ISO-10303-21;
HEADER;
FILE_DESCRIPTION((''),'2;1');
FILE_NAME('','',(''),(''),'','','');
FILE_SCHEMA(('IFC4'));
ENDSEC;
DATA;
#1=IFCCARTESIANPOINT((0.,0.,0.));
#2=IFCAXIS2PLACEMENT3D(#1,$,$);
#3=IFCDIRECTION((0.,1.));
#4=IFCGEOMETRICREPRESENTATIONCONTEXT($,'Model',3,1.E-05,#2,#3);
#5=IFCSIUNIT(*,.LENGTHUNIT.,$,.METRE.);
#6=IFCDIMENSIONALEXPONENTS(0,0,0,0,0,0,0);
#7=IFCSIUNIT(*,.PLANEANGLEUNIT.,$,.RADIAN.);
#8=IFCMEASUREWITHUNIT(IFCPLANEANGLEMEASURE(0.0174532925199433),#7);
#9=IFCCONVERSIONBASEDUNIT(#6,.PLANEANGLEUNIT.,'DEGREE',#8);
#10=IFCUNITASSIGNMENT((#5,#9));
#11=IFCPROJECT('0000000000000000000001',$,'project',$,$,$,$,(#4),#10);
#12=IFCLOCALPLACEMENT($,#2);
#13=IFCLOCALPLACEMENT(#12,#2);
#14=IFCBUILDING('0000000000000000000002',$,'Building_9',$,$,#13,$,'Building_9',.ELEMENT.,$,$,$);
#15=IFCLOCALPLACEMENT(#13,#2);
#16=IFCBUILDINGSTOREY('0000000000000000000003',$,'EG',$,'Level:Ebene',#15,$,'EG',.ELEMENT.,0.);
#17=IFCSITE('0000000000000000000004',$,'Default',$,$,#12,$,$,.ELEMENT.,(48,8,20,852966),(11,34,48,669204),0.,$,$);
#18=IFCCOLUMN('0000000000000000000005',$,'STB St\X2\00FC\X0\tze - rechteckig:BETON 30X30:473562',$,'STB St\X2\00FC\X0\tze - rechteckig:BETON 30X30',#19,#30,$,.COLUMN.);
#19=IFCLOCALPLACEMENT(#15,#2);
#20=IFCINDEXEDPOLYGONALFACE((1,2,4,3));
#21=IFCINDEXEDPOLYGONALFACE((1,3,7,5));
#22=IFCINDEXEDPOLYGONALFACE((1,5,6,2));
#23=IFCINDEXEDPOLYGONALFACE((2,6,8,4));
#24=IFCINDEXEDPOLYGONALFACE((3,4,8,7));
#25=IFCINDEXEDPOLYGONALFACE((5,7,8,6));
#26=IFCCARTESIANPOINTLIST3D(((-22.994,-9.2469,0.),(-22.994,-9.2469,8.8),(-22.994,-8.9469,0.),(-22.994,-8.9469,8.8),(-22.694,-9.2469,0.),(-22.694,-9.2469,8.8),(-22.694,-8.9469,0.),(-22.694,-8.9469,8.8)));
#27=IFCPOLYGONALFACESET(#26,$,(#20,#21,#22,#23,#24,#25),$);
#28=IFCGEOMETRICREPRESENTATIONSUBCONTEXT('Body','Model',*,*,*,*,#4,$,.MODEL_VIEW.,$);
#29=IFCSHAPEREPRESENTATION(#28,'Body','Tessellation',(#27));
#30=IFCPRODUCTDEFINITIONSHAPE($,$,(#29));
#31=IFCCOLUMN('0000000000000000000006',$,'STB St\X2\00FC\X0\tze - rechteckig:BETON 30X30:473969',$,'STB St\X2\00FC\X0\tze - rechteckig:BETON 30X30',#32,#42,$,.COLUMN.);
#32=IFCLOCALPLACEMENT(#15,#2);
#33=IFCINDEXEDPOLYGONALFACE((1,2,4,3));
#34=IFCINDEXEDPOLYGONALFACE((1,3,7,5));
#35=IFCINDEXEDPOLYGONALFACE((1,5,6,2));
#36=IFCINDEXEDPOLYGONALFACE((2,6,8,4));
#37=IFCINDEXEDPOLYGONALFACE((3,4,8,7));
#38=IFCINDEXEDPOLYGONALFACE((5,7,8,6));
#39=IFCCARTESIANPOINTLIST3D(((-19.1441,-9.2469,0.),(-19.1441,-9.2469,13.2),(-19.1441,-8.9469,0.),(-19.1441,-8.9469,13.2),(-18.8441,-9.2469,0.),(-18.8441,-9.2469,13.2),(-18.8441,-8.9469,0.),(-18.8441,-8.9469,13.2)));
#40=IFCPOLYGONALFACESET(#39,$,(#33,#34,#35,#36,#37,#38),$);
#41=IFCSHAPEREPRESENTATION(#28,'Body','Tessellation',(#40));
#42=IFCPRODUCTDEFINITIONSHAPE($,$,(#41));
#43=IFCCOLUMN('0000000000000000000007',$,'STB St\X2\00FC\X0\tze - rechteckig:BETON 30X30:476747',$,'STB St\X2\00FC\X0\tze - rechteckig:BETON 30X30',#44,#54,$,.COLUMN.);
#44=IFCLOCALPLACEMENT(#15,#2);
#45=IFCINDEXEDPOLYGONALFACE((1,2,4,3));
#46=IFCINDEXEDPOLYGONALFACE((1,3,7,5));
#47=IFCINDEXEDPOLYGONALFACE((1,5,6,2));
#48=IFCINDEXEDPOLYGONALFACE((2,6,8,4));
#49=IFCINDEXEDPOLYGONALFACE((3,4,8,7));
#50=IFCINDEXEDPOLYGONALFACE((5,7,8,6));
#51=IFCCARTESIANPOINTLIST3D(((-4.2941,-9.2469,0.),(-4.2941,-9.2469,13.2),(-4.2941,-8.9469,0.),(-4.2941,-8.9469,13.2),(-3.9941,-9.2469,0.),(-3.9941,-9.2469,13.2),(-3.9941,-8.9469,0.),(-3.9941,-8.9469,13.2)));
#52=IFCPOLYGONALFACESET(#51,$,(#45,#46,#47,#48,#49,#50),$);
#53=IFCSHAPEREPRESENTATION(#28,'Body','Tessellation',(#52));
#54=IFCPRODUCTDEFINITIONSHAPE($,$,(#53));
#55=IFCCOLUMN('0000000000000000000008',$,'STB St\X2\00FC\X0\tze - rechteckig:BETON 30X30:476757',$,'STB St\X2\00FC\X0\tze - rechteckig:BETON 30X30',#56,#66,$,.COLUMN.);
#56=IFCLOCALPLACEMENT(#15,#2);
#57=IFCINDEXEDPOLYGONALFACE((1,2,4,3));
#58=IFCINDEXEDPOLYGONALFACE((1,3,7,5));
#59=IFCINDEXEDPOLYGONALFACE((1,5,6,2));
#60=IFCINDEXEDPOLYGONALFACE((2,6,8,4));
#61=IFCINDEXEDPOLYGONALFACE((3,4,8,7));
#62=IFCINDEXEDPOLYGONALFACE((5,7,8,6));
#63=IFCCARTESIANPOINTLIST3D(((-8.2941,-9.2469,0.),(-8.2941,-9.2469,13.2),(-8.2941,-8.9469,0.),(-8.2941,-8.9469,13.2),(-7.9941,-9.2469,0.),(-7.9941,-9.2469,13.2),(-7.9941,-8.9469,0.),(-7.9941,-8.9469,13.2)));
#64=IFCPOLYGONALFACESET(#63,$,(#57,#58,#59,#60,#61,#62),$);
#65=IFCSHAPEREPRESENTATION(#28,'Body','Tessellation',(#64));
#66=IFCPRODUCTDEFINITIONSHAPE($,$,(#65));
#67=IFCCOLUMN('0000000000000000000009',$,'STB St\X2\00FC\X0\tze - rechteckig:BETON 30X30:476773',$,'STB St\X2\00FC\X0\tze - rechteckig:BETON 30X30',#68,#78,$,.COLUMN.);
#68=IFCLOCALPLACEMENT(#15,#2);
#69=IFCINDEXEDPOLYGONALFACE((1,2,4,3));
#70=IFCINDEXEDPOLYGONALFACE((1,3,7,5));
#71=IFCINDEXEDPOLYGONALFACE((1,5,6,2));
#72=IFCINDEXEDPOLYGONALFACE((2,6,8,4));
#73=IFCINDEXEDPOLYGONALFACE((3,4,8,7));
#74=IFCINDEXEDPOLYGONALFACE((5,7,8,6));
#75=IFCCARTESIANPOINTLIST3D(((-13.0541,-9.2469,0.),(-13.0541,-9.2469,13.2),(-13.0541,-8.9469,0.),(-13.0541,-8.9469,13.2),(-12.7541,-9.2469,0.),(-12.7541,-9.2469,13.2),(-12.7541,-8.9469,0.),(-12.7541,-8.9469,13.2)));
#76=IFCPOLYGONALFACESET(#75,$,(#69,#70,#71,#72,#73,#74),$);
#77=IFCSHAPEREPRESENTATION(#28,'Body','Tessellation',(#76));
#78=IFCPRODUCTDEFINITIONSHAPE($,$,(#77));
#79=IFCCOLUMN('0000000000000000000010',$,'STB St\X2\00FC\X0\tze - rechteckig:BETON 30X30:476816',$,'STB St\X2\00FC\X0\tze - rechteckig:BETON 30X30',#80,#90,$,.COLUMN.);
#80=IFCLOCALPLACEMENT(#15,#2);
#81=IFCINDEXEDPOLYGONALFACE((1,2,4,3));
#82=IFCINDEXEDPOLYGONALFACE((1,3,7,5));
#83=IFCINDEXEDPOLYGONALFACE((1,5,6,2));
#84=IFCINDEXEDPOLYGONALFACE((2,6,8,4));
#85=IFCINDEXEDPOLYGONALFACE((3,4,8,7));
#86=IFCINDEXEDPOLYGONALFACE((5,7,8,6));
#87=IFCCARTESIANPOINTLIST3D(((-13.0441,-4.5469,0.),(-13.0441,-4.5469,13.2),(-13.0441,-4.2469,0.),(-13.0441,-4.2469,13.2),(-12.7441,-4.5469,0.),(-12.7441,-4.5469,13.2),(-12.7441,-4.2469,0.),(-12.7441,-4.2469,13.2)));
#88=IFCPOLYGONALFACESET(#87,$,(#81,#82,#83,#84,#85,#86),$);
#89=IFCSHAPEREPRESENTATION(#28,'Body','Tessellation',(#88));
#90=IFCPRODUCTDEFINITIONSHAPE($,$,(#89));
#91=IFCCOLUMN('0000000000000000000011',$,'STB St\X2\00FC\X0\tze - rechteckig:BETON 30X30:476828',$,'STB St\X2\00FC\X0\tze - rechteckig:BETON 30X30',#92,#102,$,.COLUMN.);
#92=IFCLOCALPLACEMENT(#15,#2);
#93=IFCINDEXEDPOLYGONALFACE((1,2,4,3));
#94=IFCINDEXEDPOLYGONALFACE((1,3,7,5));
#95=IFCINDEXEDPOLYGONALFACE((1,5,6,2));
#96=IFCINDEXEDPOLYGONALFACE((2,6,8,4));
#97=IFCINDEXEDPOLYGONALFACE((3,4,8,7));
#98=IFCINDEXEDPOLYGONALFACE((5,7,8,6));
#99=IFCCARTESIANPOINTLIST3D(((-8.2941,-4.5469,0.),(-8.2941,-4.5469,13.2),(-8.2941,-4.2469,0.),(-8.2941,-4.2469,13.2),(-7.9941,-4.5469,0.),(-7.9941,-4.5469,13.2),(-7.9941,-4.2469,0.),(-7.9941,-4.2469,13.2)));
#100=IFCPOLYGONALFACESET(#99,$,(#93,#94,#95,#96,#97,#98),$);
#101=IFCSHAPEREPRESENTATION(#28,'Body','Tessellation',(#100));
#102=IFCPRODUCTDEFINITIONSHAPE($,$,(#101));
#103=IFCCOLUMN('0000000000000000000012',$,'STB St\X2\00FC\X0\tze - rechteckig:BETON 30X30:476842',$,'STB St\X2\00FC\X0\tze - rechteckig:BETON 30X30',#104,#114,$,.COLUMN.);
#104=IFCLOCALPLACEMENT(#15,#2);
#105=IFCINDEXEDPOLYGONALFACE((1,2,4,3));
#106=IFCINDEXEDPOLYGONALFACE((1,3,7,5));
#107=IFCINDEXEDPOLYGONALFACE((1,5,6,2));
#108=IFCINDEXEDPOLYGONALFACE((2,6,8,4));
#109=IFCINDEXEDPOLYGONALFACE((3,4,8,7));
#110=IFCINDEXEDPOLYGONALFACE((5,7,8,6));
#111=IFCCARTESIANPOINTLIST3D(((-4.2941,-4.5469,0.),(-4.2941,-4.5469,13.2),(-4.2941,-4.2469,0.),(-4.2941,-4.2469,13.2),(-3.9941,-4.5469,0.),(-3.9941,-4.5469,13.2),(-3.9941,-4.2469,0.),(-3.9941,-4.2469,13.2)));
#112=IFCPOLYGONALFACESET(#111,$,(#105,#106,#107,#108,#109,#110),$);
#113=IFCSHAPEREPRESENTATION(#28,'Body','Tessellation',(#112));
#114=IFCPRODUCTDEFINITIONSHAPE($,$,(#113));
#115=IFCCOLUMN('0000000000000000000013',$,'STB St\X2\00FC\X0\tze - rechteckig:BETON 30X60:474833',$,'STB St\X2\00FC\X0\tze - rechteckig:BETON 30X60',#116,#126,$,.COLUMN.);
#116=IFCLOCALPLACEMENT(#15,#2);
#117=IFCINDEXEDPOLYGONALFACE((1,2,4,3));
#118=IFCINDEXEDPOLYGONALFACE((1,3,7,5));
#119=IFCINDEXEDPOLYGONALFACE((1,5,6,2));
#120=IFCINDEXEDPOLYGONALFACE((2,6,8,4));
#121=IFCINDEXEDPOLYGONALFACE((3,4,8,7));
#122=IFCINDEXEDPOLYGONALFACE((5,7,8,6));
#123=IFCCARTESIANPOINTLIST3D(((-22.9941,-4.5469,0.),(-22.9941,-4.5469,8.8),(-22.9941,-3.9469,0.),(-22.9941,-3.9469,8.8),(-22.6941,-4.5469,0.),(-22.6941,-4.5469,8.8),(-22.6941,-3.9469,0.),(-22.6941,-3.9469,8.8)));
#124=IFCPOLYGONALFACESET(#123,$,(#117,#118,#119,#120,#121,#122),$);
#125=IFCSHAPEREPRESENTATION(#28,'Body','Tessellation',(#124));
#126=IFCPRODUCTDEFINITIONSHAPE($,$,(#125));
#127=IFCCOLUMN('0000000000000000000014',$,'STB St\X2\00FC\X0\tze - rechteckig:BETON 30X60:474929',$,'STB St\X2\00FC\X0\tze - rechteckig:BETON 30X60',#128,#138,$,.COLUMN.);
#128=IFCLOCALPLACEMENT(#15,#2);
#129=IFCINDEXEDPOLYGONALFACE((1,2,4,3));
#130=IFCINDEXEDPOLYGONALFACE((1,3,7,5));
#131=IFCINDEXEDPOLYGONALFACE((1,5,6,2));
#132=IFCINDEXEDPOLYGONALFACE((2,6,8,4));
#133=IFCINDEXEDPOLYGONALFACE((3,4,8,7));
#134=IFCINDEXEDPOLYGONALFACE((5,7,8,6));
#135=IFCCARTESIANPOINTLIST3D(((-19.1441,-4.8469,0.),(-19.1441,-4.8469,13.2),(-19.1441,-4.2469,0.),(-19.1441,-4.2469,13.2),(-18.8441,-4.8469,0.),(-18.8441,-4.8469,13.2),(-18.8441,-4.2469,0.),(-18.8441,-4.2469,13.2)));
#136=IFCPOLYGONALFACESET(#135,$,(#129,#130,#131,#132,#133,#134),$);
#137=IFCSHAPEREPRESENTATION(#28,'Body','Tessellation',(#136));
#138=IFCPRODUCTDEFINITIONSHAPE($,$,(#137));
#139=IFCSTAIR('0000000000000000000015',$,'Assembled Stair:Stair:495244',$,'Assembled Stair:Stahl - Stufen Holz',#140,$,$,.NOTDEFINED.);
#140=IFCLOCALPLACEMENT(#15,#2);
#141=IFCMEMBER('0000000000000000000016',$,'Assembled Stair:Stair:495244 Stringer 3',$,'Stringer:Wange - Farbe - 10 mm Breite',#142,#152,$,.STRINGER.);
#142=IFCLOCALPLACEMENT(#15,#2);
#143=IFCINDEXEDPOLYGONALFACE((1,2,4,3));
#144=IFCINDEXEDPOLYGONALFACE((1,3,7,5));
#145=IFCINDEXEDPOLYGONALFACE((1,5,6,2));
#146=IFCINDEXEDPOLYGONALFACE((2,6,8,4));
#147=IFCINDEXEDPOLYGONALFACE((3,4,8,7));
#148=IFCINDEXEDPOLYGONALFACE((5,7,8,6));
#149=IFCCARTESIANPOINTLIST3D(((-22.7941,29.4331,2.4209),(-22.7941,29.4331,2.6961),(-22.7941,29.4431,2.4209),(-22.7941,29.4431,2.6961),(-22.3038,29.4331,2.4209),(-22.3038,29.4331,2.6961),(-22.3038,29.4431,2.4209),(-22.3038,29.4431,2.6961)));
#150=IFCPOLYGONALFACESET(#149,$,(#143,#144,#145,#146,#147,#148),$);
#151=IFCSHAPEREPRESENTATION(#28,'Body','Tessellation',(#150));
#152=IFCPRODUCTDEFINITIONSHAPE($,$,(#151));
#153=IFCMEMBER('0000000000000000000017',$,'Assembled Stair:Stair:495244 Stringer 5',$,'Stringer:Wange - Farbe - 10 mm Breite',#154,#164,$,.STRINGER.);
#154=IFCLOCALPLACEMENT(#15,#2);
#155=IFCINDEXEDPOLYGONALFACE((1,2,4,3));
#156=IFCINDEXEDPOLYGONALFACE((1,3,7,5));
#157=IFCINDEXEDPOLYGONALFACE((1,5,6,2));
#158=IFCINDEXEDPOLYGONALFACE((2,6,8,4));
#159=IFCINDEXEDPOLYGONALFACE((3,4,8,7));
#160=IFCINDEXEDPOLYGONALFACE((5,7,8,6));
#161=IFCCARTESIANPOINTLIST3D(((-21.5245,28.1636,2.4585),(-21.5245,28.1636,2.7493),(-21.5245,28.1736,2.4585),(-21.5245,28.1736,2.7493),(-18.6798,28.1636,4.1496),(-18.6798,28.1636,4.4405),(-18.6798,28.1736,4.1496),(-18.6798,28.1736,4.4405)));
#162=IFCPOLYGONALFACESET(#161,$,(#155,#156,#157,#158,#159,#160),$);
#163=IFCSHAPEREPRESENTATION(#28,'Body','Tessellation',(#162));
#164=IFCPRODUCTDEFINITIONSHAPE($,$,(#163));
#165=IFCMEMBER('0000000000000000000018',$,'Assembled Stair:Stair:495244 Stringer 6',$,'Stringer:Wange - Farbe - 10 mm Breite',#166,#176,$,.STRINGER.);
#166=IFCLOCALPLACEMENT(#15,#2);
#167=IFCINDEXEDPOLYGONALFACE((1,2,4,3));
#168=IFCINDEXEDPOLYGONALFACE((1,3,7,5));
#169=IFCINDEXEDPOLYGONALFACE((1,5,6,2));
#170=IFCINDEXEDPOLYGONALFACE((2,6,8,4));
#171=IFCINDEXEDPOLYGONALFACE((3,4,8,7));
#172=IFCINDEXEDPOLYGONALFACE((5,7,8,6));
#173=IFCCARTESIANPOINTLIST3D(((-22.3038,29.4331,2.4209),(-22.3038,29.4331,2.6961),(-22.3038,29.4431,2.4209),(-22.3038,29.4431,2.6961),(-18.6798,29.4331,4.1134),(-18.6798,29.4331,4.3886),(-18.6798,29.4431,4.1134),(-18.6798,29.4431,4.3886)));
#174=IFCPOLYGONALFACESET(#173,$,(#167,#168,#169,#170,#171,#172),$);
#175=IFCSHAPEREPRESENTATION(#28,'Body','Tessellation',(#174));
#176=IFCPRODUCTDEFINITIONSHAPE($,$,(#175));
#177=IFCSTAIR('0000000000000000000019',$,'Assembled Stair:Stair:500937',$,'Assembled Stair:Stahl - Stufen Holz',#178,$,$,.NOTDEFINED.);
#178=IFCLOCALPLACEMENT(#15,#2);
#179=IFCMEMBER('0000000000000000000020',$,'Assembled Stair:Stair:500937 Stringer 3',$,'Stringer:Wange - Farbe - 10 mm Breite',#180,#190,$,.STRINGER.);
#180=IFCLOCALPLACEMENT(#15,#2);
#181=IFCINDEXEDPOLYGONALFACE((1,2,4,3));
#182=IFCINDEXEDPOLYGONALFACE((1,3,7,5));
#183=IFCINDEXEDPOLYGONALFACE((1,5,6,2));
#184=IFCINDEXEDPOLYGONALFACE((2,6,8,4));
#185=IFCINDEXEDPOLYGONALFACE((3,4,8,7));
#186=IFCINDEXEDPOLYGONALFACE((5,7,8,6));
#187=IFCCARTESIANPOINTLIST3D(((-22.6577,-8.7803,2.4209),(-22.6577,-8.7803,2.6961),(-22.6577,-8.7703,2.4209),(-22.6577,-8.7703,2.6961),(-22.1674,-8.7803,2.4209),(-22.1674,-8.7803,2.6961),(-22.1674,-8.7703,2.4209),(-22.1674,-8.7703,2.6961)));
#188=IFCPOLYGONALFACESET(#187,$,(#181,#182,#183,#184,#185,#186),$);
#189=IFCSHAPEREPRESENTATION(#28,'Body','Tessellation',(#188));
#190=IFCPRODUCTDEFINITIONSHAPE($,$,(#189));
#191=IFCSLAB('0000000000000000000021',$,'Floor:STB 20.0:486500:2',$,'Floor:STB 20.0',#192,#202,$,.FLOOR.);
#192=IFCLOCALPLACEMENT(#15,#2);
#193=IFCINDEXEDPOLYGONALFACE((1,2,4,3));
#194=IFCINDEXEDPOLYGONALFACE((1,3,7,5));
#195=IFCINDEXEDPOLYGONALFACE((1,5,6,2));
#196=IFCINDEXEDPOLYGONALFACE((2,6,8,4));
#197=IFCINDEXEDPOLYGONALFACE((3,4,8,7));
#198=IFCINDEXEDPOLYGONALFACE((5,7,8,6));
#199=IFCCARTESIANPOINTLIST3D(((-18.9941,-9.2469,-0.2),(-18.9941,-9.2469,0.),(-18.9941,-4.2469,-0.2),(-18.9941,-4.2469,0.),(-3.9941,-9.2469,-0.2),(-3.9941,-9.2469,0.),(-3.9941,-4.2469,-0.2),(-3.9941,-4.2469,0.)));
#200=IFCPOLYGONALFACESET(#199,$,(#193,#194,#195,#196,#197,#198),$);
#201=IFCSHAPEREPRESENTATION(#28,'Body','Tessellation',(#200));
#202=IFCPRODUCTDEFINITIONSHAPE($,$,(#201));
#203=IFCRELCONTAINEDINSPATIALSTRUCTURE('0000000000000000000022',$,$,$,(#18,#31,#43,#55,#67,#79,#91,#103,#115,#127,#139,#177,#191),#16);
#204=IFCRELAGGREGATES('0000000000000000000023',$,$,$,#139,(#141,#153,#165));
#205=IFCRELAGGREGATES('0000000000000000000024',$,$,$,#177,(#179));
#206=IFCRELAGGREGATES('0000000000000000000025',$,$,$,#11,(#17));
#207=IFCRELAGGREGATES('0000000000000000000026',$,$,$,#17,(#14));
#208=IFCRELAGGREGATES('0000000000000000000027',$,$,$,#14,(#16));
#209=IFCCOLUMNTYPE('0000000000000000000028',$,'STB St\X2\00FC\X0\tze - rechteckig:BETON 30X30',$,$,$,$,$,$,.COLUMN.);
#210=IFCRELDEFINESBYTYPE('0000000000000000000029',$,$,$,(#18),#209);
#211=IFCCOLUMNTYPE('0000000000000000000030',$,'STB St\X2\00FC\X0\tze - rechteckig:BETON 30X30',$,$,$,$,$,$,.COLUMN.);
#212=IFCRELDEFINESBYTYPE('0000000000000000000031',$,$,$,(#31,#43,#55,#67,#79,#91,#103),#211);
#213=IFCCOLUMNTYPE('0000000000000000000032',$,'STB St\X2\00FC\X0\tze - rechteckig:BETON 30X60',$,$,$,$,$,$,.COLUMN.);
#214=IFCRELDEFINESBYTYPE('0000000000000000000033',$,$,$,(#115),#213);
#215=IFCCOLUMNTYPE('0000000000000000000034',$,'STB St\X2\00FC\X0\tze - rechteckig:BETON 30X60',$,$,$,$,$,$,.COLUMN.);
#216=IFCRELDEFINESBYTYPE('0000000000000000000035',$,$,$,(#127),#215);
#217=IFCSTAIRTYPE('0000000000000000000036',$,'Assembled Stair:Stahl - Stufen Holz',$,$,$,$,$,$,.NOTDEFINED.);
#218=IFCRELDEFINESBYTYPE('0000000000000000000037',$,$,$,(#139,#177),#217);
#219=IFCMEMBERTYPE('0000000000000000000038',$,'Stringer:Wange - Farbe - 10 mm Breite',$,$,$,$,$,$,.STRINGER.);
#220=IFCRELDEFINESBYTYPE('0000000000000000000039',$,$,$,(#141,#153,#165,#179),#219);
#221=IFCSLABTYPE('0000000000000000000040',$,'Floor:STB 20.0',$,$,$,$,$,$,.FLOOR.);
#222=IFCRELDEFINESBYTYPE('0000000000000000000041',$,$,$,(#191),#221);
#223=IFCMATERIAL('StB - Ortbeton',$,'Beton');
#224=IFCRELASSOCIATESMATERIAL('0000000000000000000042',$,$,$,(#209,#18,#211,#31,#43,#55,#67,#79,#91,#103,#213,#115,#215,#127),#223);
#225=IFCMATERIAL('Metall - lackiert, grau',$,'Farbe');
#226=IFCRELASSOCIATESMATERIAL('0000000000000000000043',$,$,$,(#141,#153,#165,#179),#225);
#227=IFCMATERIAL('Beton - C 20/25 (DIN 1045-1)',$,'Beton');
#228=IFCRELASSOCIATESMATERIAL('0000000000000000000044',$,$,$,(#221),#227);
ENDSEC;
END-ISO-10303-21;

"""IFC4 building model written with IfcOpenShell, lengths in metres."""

from ifc_helpers import new_model, entity, si_unit, converted_unit, direction, frame, frame_2d, origin, place, context, subcontext, project, spatial, indexed_curve, rectangle, outline, extrude, source, transform, mapped, material, type_object, type_shapes, element, aggregate, save


model = new_model("IFC4")

# Units and contexts
model_context = context("Model", 3, precision=1e-05, world=origin(), true_north=direction((0.0, 1.0)))
body_context = subcontext(model_context, "Body", "Model", "MODEL_VIEW")
ifc_project = project(units=[si_unit("LENGTHUNIT", "METRE"), converted_unit("PLANEANGLEUNIT", "DEGREE", entity("IfcPlaneAngleMeasure", 0.0174532925199433), si_unit("PLANEANGLEUNIT", "RADIAN"), dimensions=[0, 0, 0, 0, 0, 0, 0])], contexts=[model_context])

# Site, building, storey
site_placement = place(None, origin())
site = spatial("IfcSite", under=ifc_project, at=site_placement, Name="Default", CompositionType="ELEMENT", RefLatitude=(48, 8, 20, 852966), RefLongitude=(11, 34, 48, 669204), RefElevation=0.0)
building_placement = place(site_placement, origin())
building = spatial("IfcBuilding", under=site, at=building_placement, Name="Building_9", LongName="Building_9", CompositionType="ELEMENT")
storey_placement = place(building_placement, origin())
storey = spatial("IfcBuildingStorey", under=building, at=storey_placement, Name="EG", ObjectType="Level:Ebene", LongName="EG", CompositionType="ELEMENT", Elevation=0.0)

# Columns
ifc_material_1 = material(Name="StB - Ortbeton", Category="Beton")
column_type_1 = type_object("IfcColumnType", Name="STB Stütze - rechteckig:BETON 30X30", PredefinedType="COLUMN", material=ifc_material_1)
shared_shape_1 = source(origin(), body_context, "Body", "SweptSolid", [
    extrude(outline(indexed_curve([(-0.15, -0.15), (0.15, -0.15), (0.15, 0.15), (-0.15, 0.15), (-0.15, -0.15)], self_intersect=False)), frame((0.0, 0.0, 0.0), z_axis=(0.0, 0.0, 1.0), x_axis=(-1.0, 0.0, 0.0)), (0.0, 0.0, 1.0), 8.8),
])
type_shapes(column_type_1, [shared_shape_1])
column_1_placement = place(storey_placement, frame((-22.844, -9.0969, 0.0)))
element("IfcColumn", 1, at=column_1_placement, inside=storey, type_object=column_type_1, material=ifc_material_1, Name="STB Stütze - rechteckig:BETON 30X30:473562", ObjectType="STB Stütze - rechteckig:BETON 30X30", PredefinedType="COLUMN", context=body_context, shape_type="MappedRepresentation", body=[
    mapped(shared_shape_1, transform((0.0, 0.0, 0.0), scale=1.0)),
])
column_type_2 = type_object("IfcColumnType", Name="STB Stütze - rechteckig:BETON 30X30", PredefinedType="COLUMN", material=ifc_material_1)
shared_shape_2 = source(origin(), body_context, "Body", "SweptSolid", [
    extrude(outline(indexed_curve([(-0.15, -0.15), (0.15, -0.15), (0.15, 0.15), (-0.15, 0.15), (-0.15, -0.15)], self_intersect=False)), frame((0.0, 0.0, 0.0), z_axis=(0.0, 0.0, 1.0), x_axis=(-1.0, 0.0, 0.0)), (0.0, 0.0, 1.0), 13.2),
])
type_shapes(column_type_2, [shared_shape_2])
for number, where, name in (
    (2, (-18.9941, -9.0969, 0.0), "STB Stütze - rechteckig:BETON 30X30:473969"),
    (3, (-4.1441, -9.0969, 0.0), "STB Stütze - rechteckig:BETON 30X30:476747"),
    (4, (-8.1441, -9.0969, 0.0), "STB Stütze - rechteckig:BETON 30X30:476757"),
    (5, (-12.9041, -9.0969, 0.0), "STB Stütze - rechteckig:BETON 30X30:476773"),
    (6, (-12.8941, -4.3969, 0.0), "STB Stütze - rechteckig:BETON 30X30:476816"),
    (7, (-8.1441, -4.3969, 0.0), "STB Stütze - rechteckig:BETON 30X30:476828"),
    (8, (-4.1441, -4.3969, 0.0), "STB Stütze - rechteckig:BETON 30X30:476842"),
):
    element("IfcColumn", number, at=place(storey_placement, frame(where)), inside=storey, type_object=column_type_2, material=ifc_material_1, Name=name, ObjectType="STB Stütze - rechteckig:BETON 30X30", PredefinedType="COLUMN", context=body_context, shape_type="MappedRepresentation", body=[
        mapped(shared_shape_2, transform((0.0, 0.0, 0.0), scale=1.0)),
    ])
column_type_3 = type_object("IfcColumnType", Name="STB Stütze - rechteckig:BETON 30X60", PredefinedType="COLUMN", material=ifc_material_1)
shared_shape_3 = source(origin(), body_context, "Body", "SweptSolid", [
    extrude(outline(indexed_curve([(-0.15, -0.3), (0.15, -0.3), (0.15, 0.3), (-0.15, 0.3), (-0.15, -0.3)], self_intersect=False)), frame((0.0, 0.0, 0.0), z_axis=(0.0, 0.0, 1.0), x_axis=(-1.0, 0.0, 0.0)), (0.0, 0.0, 1.0), 8.8),
])
type_shapes(column_type_3, [shared_shape_3])
column_2_placement = place(storey_placement, frame((-22.8441, -4.2469, 0.0)))
element("IfcColumn", 9, at=column_2_placement, inside=storey, type_object=column_type_3, material=ifc_material_1, Name="STB Stütze - rechteckig:BETON 30X60:474833", ObjectType="STB Stütze - rechteckig:BETON 30X60", PredefinedType="COLUMN", context=body_context, shape_type="MappedRepresentation", body=[
    mapped(shared_shape_3, transform((0.0, 0.0, 0.0), scale=1.0)),
])
column_type_4 = type_object("IfcColumnType", Name="STB Stütze - rechteckig:BETON 30X60", PredefinedType="COLUMN", material=ifc_material_1)
shared_shape_4 = source(origin(), body_context, "Body", "SweptSolid", [
    extrude(outline(indexed_curve([(-0.15, -0.3), (0.15, -0.3), (0.15, 0.3), (-0.15, 0.3), (-0.15, -0.3)], self_intersect=False)), frame((0.0, 0.0, 0.0), z_axis=(0.0, 0.0, 1.0), x_axis=(-1.0, 0.0, 0.0)), (0.0, 0.0, 1.0), 13.2),
])
type_shapes(column_type_4, [shared_shape_4])
column_3_placement = place(storey_placement, frame((-18.9941, -4.5469, 0.0)))
element("IfcColumn", 10, at=column_3_placement, inside=storey, type_object=column_type_4, material=ifc_material_1, Name="STB Stütze - rechteckig:BETON 30X60:474929", ObjectType="STB Stütze - rechteckig:BETON 30X60", PredefinedType="COLUMN", context=body_context, shape_type="MappedRepresentation", body=[
    mapped(shared_shape_4, transform((0.0, 0.0, 0.0), scale=1.0)),
])

# Stairs, members
stair_type = type_object("IfcStairType", Name="Assembled Stair:Stahl - Stufen Holz", PredefinedType="NOTDEFINED")
stair_1_placement = place(storey_placement, origin())
stair_1 = element("IfcStair", 11, at=stair_1_placement, inside=storey, type_object=stair_type, Name="Assembled Stair:Stair:495244", ObjectType="Assembled Stair:Stahl - Stufen Holz", PredefinedType="NOTDEFINED")
ifc_material_2 = material(Name="Metall - lackiert, grau", Category="Farbe")
member_type = type_object("IfcMemberType", Name="Stringer:Wange - Farbe - 10 mm Breite", PredefinedType="STRINGER")
member_1_placement = place(stair_1_placement, origin())
member_1 = element("IfcMember", 12, at=member_1_placement, type_object=member_type, material=ifc_material_2, Name="Assembled Stair:Stair:495244 Stringer 3", ObjectType="Stringer:Wange - Farbe - 10 mm Breite", PredefinedType="STRINGER", context=body_context, shape_type="SweptSolid", body=[
    extrude(outline(indexed_curve([(-0.2451, -0.005), (0.2451, -0.005), (0.2451, 0.005), (-0.2451, 0.005), (-0.2451, -0.005)], self_intersect=False)), frame((-22.5489, 29.4381, 2.4209)), (0.0, 0.0, 1.0), 0.2752),
])
member_2_placement = place(stair_1_placement, origin())
member_2 = element("IfcMember", 13, at=member_2_placement, type_object=member_type, material=ifc_material_2, Name="Assembled Stair:Stair:495244 Stringer 5", ObjectType="Stringer:Wange - Farbe - 10 mm Breite", PredefinedType="STRINGER", context=body_context, shape_type="SweptSolid", body=[
    extrude(outline(indexed_curve([(-1.5804, -0.125), (1.729, -0.125), (1.5804, 0.125), (-1.729, 0.125), (-1.5804, -0.125)], self_intersect=False)), frame((-20.1022, 28.1636, 3.4495), z_axis=(0.0, 1.0, 0.0), x_axis=(0.859573, 0.0, 0.511013)), (0.0, 0.0, 1.0), 0.01),
])
member_3_placement = place(stair_1_placement, origin())
member_3 = element("IfcMember", 14, at=member_3_placement, type_object=member_type, material=ifc_material_2, Name="Assembled Stair:Stair:495244 Stringer 6", ObjectType="Stringer:Wange - Farbe - 10 mm Breite", PredefinedType="STRINGER", context=body_context, shape_type="SweptSolid", body=[
    extrude(outline(indexed_curve([(-1.9416, -0.1247), (2.0581, -0.1247), (1.9416, 0.1247), (-2.0581, 0.1247), (-1.9416, -0.1247)], self_intersect=False)), frame((-20.4918, 29.4331, 3.4047), z_axis=(0.0, 1.0, 0.0), x_axis=(0.906057, 0.0, 0.423156)), (0.0, 0.0, 1.0), 0.01),
])
stair_2_placement = place(storey_placement, origin())
stair_2 = element("IfcStair", 15, at=stair_2_placement, inside=storey, type_object=stair_type, Name="Assembled Stair:Stair:500937", ObjectType="Assembled Stair:Stahl - Stufen Holz", PredefinedType="NOTDEFINED")
member_4_placement = place(stair_2_placement, origin())
member_4 = element("IfcMember", 16, at=member_4_placement, type_object=member_type, material=ifc_material_2, Name="Assembled Stair:Stair:500937 Stringer 3", ObjectType="Stringer:Wange - Farbe - 10 mm Breite", PredefinedType="STRINGER", context=body_context, shape_type="SweptSolid", body=[
    extrude(outline(indexed_curve([(-0.2451, -0.005), (0.2451, -0.005), (0.2451, 0.005), (-0.2451, 0.005), (-0.2451, -0.005)], self_intersect=False)), frame((-22.4126, -8.7753, 2.4209)), (0.0, 0.0, 1.0), 0.2752),
])

# Slab
ifc_material_3 = material(Name="Beton - C 20/25 (DIN 1045-1)", Category="Beton")
slab_type = type_object("IfcSlabType", Name="Floor:STB 20.0", PredefinedType="FLOOR", material=ifc_material_3)
slab_1_placement = place(storey_placement, frame((-18.9941, -9.2469, -0.2)))
element("IfcSlab", 17, at=slab_1_placement, inside=storey, type_object=slab_type, Name="Floor:STB 20.0:486500:2", ObjectType="Floor:STB 20.0", PredefinedType="FLOOR", context=body_context, shape_type="SweptSolid", body=[
    extrude(rectangle(XDim=15.0, YDim=5.0, at=frame_2d((0.0, -17.0), x_axis=(-1.0, 0.0))), frame((7.5, 19.5, 0.2), z_axis=(0.0, 0.0, -1.0), x_axis=(-1.0, 0.0, 0.0)), (0.0, 0.0, 1.0), 0.2),
])

aggregate(stair_1, [member_1, member_2, member_3])
aggregate(stair_2, [member_4])

save(model, "model.ifc")
